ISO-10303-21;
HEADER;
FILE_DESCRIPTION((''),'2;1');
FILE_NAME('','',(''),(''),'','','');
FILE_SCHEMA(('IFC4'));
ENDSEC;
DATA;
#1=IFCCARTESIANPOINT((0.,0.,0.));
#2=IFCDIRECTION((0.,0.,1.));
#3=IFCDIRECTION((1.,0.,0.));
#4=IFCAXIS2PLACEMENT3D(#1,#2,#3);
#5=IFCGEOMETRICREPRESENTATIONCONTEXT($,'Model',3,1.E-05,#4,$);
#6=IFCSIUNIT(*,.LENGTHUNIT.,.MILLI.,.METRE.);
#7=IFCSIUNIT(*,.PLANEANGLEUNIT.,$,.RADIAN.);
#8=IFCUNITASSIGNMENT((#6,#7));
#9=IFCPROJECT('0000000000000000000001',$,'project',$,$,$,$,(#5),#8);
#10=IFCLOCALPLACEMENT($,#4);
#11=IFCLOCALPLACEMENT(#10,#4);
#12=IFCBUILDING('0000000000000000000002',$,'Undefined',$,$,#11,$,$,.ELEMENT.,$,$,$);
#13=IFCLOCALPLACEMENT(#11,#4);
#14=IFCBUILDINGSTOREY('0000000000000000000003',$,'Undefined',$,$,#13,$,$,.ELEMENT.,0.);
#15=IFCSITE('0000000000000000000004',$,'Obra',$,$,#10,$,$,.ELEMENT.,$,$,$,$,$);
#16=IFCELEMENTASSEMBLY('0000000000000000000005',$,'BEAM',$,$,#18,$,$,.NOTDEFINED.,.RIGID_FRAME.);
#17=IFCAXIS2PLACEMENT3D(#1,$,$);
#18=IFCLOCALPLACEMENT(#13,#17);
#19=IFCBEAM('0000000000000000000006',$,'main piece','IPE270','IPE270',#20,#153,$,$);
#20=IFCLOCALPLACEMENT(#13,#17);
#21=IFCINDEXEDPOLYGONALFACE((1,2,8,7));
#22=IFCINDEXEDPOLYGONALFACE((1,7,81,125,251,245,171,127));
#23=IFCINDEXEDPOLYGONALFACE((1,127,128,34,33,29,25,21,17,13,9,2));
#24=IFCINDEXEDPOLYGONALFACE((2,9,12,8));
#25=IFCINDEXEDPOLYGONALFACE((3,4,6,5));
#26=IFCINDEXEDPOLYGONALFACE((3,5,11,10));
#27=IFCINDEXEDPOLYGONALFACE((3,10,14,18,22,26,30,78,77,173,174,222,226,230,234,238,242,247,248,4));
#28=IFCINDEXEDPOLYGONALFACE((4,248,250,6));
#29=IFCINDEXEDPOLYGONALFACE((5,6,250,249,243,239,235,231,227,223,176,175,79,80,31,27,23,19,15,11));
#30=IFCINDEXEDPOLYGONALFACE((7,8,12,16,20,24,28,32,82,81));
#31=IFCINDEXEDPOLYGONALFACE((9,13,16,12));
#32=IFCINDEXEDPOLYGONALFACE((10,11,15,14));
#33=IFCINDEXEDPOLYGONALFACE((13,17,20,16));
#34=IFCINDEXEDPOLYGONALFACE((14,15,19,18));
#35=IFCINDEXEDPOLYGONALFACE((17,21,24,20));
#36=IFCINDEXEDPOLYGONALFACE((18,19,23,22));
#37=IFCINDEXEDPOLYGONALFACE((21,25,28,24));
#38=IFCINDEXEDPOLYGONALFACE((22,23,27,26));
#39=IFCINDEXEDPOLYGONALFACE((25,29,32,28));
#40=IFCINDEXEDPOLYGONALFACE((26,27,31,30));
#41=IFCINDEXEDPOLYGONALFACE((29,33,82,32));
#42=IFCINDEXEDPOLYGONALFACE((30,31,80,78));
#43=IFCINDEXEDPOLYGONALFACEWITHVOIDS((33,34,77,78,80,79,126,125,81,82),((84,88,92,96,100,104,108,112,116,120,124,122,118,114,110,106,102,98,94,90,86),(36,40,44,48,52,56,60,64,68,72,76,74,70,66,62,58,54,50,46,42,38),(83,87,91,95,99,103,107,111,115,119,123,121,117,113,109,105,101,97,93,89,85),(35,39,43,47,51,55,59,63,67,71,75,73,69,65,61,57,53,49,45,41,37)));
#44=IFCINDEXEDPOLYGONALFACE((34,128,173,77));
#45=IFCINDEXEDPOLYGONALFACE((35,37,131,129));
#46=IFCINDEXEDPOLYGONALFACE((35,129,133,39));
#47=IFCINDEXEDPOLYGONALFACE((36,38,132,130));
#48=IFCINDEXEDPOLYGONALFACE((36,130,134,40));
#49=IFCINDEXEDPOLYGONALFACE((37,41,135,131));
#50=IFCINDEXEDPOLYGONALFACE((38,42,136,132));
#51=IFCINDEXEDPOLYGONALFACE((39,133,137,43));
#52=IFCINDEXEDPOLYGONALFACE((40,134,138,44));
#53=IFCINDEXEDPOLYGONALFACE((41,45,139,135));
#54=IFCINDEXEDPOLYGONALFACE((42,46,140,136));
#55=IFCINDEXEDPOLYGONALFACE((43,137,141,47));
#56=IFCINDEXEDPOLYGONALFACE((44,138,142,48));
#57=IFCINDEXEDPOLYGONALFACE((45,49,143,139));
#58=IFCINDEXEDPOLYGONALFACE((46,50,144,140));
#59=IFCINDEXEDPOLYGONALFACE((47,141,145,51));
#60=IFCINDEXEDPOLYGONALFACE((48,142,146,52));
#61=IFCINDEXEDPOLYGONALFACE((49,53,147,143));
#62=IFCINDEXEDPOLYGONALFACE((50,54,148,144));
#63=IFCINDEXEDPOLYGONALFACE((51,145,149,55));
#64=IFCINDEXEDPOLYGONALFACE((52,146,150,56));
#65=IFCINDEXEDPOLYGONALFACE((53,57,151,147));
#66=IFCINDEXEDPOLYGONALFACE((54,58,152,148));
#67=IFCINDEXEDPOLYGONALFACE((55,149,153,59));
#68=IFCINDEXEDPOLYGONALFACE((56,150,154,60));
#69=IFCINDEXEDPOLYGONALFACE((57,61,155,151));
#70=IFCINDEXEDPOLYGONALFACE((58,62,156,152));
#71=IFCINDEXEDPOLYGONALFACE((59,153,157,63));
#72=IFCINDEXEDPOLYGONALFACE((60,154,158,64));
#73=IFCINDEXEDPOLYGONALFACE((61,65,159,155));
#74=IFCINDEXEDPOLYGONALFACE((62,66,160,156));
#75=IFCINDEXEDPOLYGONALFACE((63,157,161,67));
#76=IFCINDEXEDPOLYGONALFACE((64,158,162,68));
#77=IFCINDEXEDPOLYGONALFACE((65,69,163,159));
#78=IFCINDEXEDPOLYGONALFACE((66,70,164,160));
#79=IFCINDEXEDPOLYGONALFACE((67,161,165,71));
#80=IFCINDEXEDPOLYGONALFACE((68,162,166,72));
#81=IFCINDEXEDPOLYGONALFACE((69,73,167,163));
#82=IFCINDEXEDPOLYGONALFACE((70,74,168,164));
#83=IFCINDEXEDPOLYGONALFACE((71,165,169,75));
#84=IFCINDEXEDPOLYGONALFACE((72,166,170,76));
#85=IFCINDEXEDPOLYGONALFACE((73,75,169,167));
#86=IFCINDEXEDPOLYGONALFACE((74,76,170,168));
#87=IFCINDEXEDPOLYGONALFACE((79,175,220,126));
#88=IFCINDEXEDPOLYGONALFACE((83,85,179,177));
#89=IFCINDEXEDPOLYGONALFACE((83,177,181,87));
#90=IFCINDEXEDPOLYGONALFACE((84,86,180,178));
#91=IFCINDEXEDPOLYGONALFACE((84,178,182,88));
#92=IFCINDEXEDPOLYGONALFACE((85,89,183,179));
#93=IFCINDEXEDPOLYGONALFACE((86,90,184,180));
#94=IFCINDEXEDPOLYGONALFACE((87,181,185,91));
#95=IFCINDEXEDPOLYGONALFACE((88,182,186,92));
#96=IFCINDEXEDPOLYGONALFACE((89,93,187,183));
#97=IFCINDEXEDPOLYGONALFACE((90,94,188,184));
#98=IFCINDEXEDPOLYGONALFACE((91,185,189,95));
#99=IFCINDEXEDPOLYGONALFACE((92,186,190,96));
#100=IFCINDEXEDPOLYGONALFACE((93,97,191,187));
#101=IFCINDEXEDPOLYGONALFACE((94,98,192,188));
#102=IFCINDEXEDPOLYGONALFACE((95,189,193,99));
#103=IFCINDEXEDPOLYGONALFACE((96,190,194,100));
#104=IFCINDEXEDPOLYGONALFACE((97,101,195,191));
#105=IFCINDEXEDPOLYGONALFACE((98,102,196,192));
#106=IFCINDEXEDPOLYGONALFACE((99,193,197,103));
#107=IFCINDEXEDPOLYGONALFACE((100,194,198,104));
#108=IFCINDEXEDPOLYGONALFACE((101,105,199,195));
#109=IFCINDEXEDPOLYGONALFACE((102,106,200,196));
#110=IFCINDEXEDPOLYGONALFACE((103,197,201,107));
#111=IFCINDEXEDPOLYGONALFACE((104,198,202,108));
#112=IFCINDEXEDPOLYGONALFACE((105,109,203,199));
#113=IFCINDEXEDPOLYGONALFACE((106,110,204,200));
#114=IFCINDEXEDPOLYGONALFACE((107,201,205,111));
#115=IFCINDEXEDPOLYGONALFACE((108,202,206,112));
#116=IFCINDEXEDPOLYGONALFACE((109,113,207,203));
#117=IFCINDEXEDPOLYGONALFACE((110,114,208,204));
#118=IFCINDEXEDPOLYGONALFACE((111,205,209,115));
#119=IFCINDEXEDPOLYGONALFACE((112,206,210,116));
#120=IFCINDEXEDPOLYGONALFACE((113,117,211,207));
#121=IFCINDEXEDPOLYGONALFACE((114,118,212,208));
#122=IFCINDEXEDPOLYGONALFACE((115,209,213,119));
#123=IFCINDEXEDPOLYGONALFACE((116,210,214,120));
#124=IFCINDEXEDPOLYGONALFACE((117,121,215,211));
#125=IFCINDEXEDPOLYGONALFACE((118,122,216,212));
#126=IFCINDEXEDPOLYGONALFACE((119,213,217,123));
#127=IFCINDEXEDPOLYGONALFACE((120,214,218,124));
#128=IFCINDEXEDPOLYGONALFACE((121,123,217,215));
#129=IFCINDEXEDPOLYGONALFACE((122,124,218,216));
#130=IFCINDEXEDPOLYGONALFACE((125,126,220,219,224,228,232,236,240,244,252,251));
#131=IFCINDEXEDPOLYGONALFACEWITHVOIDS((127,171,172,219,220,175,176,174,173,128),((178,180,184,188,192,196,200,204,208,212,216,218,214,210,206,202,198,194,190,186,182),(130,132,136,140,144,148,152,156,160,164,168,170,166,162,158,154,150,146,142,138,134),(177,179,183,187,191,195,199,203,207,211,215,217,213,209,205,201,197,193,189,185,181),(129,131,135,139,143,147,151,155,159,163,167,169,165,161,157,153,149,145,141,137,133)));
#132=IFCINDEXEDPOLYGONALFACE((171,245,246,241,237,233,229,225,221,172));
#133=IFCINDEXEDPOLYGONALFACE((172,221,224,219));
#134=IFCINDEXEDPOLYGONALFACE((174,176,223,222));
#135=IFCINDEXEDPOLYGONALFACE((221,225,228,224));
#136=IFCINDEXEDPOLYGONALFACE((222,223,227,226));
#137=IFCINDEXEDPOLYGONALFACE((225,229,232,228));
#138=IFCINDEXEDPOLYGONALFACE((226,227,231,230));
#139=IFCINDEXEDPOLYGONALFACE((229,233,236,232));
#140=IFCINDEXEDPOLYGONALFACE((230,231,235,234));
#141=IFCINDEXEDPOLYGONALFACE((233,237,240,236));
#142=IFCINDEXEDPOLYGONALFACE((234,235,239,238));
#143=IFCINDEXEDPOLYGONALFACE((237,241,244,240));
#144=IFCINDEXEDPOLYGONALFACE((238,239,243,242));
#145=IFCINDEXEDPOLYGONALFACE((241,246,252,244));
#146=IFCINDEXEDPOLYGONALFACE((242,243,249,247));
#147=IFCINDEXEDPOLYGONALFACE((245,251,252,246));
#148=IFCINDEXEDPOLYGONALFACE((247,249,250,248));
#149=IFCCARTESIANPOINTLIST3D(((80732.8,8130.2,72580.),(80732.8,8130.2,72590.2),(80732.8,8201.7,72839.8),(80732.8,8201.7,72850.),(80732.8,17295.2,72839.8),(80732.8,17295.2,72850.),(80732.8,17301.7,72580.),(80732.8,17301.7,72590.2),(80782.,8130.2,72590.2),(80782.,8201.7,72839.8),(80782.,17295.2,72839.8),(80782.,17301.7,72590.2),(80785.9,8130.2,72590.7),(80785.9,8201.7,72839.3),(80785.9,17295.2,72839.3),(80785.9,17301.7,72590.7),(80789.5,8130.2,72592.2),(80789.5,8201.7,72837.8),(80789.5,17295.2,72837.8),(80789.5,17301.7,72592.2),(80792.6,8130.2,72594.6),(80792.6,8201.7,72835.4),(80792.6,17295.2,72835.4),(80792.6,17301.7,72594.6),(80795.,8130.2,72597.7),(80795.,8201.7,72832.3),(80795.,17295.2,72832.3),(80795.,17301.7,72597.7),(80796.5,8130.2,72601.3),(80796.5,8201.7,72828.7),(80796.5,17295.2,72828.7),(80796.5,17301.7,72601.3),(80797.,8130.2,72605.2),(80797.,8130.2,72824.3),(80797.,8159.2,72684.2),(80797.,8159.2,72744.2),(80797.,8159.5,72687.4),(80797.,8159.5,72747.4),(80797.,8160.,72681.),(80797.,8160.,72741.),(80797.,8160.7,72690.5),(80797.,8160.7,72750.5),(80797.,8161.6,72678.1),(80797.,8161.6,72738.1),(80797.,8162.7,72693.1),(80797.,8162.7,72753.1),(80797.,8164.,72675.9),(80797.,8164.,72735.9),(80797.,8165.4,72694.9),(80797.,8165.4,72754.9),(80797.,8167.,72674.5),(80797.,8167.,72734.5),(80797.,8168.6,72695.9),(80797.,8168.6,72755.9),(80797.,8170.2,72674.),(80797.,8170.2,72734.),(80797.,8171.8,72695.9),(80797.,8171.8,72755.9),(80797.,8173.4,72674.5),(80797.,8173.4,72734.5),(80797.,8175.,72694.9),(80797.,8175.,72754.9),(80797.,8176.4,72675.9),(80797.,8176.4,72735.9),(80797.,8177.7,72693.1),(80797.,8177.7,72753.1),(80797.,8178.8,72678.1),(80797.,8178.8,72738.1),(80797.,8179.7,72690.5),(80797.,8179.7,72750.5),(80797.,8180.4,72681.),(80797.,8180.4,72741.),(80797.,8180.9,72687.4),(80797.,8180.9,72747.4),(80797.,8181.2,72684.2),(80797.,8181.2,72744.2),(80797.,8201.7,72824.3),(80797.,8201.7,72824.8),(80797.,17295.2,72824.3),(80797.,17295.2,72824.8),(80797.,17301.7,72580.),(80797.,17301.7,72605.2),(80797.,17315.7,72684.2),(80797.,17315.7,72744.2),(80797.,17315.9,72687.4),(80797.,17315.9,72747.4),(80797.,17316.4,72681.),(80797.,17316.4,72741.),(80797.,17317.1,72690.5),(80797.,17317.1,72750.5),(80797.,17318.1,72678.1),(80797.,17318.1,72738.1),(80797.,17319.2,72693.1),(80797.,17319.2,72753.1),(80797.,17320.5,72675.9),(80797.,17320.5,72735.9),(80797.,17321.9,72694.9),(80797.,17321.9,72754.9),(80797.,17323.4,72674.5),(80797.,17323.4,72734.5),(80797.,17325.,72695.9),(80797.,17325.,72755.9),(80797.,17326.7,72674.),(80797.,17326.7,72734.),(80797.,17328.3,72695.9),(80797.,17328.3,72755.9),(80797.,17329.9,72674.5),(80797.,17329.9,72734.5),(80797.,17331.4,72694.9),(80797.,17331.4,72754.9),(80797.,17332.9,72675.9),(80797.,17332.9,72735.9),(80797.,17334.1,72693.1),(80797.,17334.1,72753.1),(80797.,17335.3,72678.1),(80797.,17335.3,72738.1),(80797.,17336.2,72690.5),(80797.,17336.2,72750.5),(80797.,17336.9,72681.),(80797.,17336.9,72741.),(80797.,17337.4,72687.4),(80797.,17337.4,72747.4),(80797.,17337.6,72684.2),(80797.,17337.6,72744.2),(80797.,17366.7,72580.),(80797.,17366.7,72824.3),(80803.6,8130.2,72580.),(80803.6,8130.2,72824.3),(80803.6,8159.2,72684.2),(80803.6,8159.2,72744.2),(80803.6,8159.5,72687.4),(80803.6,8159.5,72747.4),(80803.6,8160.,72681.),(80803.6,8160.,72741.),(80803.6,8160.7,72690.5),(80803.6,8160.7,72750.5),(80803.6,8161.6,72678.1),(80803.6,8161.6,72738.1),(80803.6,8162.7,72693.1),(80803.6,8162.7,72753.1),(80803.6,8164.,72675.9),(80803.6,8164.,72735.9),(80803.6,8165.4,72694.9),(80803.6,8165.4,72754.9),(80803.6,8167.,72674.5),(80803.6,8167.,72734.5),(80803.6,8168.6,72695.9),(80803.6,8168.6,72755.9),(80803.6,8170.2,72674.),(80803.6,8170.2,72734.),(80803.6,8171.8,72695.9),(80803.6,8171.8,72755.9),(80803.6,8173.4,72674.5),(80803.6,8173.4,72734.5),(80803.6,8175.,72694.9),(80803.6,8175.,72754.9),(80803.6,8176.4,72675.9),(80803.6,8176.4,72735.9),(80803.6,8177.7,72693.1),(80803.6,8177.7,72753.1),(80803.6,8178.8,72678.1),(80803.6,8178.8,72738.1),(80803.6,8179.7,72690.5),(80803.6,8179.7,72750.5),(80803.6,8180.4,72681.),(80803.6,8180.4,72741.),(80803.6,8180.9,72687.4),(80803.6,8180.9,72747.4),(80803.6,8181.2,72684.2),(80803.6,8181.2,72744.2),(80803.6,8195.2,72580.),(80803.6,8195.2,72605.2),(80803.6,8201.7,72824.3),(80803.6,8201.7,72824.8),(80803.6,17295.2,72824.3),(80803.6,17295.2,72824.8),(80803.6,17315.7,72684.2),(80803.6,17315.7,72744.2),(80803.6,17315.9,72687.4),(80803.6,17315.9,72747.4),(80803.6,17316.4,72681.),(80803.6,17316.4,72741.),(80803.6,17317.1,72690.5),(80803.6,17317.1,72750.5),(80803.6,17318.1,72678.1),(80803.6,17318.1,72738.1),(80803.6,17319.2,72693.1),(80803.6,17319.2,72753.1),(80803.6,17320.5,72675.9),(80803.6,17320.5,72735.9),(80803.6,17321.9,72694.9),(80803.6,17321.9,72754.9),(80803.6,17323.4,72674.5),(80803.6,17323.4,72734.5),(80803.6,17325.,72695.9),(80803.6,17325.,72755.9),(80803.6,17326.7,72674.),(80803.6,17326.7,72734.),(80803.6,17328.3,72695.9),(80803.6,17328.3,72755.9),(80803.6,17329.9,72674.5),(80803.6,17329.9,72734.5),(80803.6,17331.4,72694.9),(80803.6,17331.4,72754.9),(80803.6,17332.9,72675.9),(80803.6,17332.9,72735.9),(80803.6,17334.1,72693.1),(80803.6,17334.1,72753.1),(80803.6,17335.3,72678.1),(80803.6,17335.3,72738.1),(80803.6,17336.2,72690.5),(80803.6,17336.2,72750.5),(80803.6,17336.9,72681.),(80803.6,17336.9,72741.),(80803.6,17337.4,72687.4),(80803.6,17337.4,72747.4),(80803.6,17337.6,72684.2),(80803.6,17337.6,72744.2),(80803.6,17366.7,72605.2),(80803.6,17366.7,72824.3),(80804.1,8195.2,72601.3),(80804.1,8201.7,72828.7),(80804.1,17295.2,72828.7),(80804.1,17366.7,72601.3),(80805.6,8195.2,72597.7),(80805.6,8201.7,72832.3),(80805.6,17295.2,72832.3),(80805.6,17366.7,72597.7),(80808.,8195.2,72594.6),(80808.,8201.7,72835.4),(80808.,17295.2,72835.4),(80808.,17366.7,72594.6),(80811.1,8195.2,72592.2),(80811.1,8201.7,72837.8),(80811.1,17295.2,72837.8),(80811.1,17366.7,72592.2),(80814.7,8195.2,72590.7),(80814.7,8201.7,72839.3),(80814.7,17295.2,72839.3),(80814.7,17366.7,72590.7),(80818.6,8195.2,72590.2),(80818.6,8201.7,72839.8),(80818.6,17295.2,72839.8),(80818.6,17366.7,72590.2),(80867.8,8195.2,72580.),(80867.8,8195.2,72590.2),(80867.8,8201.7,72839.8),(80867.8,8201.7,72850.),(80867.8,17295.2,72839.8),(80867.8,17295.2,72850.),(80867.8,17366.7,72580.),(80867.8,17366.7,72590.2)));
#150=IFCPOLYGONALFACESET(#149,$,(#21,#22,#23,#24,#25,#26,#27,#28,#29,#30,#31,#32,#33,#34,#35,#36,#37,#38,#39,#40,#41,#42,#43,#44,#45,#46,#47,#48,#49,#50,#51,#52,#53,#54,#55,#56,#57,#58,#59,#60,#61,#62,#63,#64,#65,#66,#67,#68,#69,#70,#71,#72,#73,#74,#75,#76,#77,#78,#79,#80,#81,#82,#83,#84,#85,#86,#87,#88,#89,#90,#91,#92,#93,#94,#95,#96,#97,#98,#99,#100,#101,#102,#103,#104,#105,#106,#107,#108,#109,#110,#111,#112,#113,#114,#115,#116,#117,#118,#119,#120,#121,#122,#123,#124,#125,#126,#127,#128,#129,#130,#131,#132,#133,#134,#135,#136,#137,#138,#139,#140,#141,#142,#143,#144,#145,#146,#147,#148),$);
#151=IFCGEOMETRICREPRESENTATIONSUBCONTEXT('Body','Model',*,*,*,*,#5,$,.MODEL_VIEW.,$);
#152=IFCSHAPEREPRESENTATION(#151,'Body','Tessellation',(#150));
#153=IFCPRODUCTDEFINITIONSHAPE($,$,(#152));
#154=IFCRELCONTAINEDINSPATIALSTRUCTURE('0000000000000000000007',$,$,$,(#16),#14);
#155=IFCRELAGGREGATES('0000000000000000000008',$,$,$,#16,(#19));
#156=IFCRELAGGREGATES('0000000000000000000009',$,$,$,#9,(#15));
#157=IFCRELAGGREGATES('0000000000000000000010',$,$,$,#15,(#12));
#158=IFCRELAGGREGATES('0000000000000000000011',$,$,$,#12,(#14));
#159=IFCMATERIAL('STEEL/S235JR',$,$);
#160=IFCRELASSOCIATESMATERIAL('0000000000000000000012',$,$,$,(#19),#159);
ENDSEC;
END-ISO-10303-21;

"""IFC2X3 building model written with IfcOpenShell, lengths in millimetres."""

from ifc_helpers import new_model, si_unit, frame, origin_with_axes, origin_2d_with_axis, place, context, subcontext, project, spatial, rectangle, circle, i_section, extrude, clip, halfspace, source, transform, mapped, material, element, aggregate, save


model = new_model("IFC2X3")

# Units and contexts
model_context = context("Model", 3, precision=1e-05, world=origin_with_axes())
body_context = subcontext(model_context, "Body", "Model", "MODEL_VIEW")
ifc_project = project(units=[si_unit("LENGTHUNIT", "METRE", prefix="MILLI"), si_unit("PLANEANGLEUNIT", "RADIAN")], contexts=[model_context])

# Site, building, storey
site_placement = place(None, origin_with_axes())
site = spatial("IfcSite", under=ifc_project, at=site_placement, Name="Obra", CompositionType="ELEMENT")
building_placement = place(site_placement, origin_with_axes())
building = spatial("IfcBuilding", under=site, at=building_placement, Name="Undefined", CompositionType="ELEMENT")
storey_placement = place(building_placement, origin_with_axes())
storey = spatial("IfcBuildingStorey", under=building, at=storey_placement, Name="Undefined", CompositionType="ELEMENT", Elevation=0.0)

# Shared definitions
ifc_material = material(Name="STEEL/S235JR")

# Element assembly, beam, openings
assembly_1_placement = place(storey_placement, origin_with_axes())
assembly_1 = element("IfcElementAssembly", 1, at=assembly_1_placement, inside=storey, Name="BEAM", AssemblyPlace="NOTDEFINED", PredefinedType="RIGID_FRAME")
beam_1_placement = place(assembly_1_placement, frame((80800.3, 8215.2, 72715.0), z_axis=(0.0, 0.0, 1.0), x_axis=(0.0, 1.0, 0.0)))
beam_1 = element("IfcBeam", 2, at=beam_1_placement, material=ifc_material, Name="main piece", Description="IPE270", ObjectType="IPE270", context=body_context, shape_type="Clipping", body=[
    clip(clip(extrude(i_section(OverallWidth=135.0, OverallDepth=270.0, WebThickness=6.6, FlangeThickness=10.2, FilletRadius=15.0, at=origin_2d_with_axis()), frame((9151.5, 0.0, 0.0), z_axis=(-1.0, 0.0, 0.0), x_axis=(0.0, -1.0, 0.0)), (0.0, 0.0, 1.0), 9236.5), halfspace(frame((9151.5, 0.0, -235.0), z_axis=(-1.0, 0.0, 0.0), x_axis=(0.0, 1.0, 0.0)), True)), halfspace(frame((-85.0, 0.0, -235.0), z_axis=(1.0, 0.0, 0.0), x_axis=(0.0, -1.0, 0.0)), True)),
])
opening_1_placement = place(assembly_1_placement, frame((80800.3, 8215.2, 72715.0), z_axis=(0.0, 0.0, 1.0), x_axis=(0.0, 1.0, 0.0)))
element("IfcOpeningElement", 3, at=opening_1_placement, cuts=beam_1, ObjectType="Recess", context=body_context, shape_type="SweptSolid", body=[
    extrude(rectangle(XDim=75.0, YDim=300.0, at=origin_2d_with_axis()), frame((9124.0, 153.3, 124.3), z_axis=(0.0, 0.0, -1.0), x_axis=(-1.0, 0.0, 0.0)), (0.0, 0.0, 1.0), 278.6),
])
opening_2_placement = place(assembly_1_placement, frame((80800.3, 8215.2, 72715.0), z_axis=(0.0, 0.0, 1.0), x_axis=(0.0, 1.0, 0.0)))
element("IfcOpeningElement", 4, at=opening_2_placement, cuts=beam_1, ObjectType="Recess", context=body_context, shape_type="SweptSolid", body=[
    extrude(rectangle(XDim=26.7, YDim=83.5, at=origin_2d_with_axis()), frame((9121.7, 68.5, 122.7), z_axis=(0.0, -1.0, 0.0), x_axis=(0.0, 0.0, -1.0)), (0.0, 0.0, 1.0), 137.0),
])
opening_3_placement = place(assembly_1_placement, frame((80800.3, 8215.2, 72715.0), z_axis=(0.0, 0.0, 1.0), x_axis=(0.0, 1.0, 0.0)))
element("IfcOpeningElement", 5, at=opening_3_placement, cuts=beam_1, ObjectType="Recess", context=body_context, shape_type="SweptSolid", body=[
    extrude(rectangle(XDim=75.0, YDim=300.0, at=origin_2d_with_axis()), frame((-57.5, -153.3, 124.3), z_axis=(0.0, 0.0, -1.0), x_axis=(1.0, 0.0, 0.0)), (0.0, 0.0, 1.0), 278.6),
])
opening_4_placement = place(assembly_1_placement, frame((80800.3, 8215.2, 72715.0), z_axis=(0.0, 0.0, 1.0), x_axis=(0.0, 1.0, 0.0)))
element("IfcOpeningElement", 6, at=opening_4_placement, cuts=beam_1, ObjectType="Recess", context=body_context, shape_type="SweptSolid", body=[
    extrude(rectangle(XDim=26.7, YDim=83.5, at=origin_2d_with_axis()), frame((-55.3, -68.5, 122.7), z_axis=(0.0, 1.0, 0.0), x_axis=(0.0, 0.0, -1.0)), (0.0, 0.0, 1.0), 137.0),
])
shared_shape = source(origin_with_axes(), body_context, "Body", "SweptSolid", [
    extrude(circle(Radius=11.0, at=origin_2d_with_axis()), frame((0.0, -3.4, 0.0), z_axis=(0.0, 1.0, 0.0), x_axis=(1.0, 0.0, 0.0)), (0.0, 0.0, 1.0), 6.8),
])
opening_5_placement = place(assembly_1_placement, frame((80800.3, 17366.7, 72850.0), z_axis=(0.0, -1.0, 0.0), x_axis=(0.0, 0.0, -1.0)))
element("IfcOpeningElement", 7, at=opening_5_placement, cuts=beam_1, ObjectType="Opening", context=body_context, shape_type="MappedRepresentation", body=[
    mapped(shared_shape, transform((105.0, 0.0, 40.0))),
    mapped(shared_shape, transform((165.0, 0.0, 40.0))),
])
opening_6_placement = place(assembly_1_placement, frame((80800.3, 8130.2, 72850.0), z_axis=(0.0, 1.0, 0.0), x_axis=(0.0, 0.0, -1.0)))
element("IfcOpeningElement", 8, at=opening_6_placement, cuts=beam_1, ObjectType="Opening", context=body_context, shape_type="MappedRepresentation", body=[
    mapped(shared_shape, transform((105.0, 0.0, 40.0))),
    mapped(shared_shape, transform((165.0, 0.0, 40.0))),
])
aggregate(assembly_1, [beam_1])

save(model, "model.ifc")
